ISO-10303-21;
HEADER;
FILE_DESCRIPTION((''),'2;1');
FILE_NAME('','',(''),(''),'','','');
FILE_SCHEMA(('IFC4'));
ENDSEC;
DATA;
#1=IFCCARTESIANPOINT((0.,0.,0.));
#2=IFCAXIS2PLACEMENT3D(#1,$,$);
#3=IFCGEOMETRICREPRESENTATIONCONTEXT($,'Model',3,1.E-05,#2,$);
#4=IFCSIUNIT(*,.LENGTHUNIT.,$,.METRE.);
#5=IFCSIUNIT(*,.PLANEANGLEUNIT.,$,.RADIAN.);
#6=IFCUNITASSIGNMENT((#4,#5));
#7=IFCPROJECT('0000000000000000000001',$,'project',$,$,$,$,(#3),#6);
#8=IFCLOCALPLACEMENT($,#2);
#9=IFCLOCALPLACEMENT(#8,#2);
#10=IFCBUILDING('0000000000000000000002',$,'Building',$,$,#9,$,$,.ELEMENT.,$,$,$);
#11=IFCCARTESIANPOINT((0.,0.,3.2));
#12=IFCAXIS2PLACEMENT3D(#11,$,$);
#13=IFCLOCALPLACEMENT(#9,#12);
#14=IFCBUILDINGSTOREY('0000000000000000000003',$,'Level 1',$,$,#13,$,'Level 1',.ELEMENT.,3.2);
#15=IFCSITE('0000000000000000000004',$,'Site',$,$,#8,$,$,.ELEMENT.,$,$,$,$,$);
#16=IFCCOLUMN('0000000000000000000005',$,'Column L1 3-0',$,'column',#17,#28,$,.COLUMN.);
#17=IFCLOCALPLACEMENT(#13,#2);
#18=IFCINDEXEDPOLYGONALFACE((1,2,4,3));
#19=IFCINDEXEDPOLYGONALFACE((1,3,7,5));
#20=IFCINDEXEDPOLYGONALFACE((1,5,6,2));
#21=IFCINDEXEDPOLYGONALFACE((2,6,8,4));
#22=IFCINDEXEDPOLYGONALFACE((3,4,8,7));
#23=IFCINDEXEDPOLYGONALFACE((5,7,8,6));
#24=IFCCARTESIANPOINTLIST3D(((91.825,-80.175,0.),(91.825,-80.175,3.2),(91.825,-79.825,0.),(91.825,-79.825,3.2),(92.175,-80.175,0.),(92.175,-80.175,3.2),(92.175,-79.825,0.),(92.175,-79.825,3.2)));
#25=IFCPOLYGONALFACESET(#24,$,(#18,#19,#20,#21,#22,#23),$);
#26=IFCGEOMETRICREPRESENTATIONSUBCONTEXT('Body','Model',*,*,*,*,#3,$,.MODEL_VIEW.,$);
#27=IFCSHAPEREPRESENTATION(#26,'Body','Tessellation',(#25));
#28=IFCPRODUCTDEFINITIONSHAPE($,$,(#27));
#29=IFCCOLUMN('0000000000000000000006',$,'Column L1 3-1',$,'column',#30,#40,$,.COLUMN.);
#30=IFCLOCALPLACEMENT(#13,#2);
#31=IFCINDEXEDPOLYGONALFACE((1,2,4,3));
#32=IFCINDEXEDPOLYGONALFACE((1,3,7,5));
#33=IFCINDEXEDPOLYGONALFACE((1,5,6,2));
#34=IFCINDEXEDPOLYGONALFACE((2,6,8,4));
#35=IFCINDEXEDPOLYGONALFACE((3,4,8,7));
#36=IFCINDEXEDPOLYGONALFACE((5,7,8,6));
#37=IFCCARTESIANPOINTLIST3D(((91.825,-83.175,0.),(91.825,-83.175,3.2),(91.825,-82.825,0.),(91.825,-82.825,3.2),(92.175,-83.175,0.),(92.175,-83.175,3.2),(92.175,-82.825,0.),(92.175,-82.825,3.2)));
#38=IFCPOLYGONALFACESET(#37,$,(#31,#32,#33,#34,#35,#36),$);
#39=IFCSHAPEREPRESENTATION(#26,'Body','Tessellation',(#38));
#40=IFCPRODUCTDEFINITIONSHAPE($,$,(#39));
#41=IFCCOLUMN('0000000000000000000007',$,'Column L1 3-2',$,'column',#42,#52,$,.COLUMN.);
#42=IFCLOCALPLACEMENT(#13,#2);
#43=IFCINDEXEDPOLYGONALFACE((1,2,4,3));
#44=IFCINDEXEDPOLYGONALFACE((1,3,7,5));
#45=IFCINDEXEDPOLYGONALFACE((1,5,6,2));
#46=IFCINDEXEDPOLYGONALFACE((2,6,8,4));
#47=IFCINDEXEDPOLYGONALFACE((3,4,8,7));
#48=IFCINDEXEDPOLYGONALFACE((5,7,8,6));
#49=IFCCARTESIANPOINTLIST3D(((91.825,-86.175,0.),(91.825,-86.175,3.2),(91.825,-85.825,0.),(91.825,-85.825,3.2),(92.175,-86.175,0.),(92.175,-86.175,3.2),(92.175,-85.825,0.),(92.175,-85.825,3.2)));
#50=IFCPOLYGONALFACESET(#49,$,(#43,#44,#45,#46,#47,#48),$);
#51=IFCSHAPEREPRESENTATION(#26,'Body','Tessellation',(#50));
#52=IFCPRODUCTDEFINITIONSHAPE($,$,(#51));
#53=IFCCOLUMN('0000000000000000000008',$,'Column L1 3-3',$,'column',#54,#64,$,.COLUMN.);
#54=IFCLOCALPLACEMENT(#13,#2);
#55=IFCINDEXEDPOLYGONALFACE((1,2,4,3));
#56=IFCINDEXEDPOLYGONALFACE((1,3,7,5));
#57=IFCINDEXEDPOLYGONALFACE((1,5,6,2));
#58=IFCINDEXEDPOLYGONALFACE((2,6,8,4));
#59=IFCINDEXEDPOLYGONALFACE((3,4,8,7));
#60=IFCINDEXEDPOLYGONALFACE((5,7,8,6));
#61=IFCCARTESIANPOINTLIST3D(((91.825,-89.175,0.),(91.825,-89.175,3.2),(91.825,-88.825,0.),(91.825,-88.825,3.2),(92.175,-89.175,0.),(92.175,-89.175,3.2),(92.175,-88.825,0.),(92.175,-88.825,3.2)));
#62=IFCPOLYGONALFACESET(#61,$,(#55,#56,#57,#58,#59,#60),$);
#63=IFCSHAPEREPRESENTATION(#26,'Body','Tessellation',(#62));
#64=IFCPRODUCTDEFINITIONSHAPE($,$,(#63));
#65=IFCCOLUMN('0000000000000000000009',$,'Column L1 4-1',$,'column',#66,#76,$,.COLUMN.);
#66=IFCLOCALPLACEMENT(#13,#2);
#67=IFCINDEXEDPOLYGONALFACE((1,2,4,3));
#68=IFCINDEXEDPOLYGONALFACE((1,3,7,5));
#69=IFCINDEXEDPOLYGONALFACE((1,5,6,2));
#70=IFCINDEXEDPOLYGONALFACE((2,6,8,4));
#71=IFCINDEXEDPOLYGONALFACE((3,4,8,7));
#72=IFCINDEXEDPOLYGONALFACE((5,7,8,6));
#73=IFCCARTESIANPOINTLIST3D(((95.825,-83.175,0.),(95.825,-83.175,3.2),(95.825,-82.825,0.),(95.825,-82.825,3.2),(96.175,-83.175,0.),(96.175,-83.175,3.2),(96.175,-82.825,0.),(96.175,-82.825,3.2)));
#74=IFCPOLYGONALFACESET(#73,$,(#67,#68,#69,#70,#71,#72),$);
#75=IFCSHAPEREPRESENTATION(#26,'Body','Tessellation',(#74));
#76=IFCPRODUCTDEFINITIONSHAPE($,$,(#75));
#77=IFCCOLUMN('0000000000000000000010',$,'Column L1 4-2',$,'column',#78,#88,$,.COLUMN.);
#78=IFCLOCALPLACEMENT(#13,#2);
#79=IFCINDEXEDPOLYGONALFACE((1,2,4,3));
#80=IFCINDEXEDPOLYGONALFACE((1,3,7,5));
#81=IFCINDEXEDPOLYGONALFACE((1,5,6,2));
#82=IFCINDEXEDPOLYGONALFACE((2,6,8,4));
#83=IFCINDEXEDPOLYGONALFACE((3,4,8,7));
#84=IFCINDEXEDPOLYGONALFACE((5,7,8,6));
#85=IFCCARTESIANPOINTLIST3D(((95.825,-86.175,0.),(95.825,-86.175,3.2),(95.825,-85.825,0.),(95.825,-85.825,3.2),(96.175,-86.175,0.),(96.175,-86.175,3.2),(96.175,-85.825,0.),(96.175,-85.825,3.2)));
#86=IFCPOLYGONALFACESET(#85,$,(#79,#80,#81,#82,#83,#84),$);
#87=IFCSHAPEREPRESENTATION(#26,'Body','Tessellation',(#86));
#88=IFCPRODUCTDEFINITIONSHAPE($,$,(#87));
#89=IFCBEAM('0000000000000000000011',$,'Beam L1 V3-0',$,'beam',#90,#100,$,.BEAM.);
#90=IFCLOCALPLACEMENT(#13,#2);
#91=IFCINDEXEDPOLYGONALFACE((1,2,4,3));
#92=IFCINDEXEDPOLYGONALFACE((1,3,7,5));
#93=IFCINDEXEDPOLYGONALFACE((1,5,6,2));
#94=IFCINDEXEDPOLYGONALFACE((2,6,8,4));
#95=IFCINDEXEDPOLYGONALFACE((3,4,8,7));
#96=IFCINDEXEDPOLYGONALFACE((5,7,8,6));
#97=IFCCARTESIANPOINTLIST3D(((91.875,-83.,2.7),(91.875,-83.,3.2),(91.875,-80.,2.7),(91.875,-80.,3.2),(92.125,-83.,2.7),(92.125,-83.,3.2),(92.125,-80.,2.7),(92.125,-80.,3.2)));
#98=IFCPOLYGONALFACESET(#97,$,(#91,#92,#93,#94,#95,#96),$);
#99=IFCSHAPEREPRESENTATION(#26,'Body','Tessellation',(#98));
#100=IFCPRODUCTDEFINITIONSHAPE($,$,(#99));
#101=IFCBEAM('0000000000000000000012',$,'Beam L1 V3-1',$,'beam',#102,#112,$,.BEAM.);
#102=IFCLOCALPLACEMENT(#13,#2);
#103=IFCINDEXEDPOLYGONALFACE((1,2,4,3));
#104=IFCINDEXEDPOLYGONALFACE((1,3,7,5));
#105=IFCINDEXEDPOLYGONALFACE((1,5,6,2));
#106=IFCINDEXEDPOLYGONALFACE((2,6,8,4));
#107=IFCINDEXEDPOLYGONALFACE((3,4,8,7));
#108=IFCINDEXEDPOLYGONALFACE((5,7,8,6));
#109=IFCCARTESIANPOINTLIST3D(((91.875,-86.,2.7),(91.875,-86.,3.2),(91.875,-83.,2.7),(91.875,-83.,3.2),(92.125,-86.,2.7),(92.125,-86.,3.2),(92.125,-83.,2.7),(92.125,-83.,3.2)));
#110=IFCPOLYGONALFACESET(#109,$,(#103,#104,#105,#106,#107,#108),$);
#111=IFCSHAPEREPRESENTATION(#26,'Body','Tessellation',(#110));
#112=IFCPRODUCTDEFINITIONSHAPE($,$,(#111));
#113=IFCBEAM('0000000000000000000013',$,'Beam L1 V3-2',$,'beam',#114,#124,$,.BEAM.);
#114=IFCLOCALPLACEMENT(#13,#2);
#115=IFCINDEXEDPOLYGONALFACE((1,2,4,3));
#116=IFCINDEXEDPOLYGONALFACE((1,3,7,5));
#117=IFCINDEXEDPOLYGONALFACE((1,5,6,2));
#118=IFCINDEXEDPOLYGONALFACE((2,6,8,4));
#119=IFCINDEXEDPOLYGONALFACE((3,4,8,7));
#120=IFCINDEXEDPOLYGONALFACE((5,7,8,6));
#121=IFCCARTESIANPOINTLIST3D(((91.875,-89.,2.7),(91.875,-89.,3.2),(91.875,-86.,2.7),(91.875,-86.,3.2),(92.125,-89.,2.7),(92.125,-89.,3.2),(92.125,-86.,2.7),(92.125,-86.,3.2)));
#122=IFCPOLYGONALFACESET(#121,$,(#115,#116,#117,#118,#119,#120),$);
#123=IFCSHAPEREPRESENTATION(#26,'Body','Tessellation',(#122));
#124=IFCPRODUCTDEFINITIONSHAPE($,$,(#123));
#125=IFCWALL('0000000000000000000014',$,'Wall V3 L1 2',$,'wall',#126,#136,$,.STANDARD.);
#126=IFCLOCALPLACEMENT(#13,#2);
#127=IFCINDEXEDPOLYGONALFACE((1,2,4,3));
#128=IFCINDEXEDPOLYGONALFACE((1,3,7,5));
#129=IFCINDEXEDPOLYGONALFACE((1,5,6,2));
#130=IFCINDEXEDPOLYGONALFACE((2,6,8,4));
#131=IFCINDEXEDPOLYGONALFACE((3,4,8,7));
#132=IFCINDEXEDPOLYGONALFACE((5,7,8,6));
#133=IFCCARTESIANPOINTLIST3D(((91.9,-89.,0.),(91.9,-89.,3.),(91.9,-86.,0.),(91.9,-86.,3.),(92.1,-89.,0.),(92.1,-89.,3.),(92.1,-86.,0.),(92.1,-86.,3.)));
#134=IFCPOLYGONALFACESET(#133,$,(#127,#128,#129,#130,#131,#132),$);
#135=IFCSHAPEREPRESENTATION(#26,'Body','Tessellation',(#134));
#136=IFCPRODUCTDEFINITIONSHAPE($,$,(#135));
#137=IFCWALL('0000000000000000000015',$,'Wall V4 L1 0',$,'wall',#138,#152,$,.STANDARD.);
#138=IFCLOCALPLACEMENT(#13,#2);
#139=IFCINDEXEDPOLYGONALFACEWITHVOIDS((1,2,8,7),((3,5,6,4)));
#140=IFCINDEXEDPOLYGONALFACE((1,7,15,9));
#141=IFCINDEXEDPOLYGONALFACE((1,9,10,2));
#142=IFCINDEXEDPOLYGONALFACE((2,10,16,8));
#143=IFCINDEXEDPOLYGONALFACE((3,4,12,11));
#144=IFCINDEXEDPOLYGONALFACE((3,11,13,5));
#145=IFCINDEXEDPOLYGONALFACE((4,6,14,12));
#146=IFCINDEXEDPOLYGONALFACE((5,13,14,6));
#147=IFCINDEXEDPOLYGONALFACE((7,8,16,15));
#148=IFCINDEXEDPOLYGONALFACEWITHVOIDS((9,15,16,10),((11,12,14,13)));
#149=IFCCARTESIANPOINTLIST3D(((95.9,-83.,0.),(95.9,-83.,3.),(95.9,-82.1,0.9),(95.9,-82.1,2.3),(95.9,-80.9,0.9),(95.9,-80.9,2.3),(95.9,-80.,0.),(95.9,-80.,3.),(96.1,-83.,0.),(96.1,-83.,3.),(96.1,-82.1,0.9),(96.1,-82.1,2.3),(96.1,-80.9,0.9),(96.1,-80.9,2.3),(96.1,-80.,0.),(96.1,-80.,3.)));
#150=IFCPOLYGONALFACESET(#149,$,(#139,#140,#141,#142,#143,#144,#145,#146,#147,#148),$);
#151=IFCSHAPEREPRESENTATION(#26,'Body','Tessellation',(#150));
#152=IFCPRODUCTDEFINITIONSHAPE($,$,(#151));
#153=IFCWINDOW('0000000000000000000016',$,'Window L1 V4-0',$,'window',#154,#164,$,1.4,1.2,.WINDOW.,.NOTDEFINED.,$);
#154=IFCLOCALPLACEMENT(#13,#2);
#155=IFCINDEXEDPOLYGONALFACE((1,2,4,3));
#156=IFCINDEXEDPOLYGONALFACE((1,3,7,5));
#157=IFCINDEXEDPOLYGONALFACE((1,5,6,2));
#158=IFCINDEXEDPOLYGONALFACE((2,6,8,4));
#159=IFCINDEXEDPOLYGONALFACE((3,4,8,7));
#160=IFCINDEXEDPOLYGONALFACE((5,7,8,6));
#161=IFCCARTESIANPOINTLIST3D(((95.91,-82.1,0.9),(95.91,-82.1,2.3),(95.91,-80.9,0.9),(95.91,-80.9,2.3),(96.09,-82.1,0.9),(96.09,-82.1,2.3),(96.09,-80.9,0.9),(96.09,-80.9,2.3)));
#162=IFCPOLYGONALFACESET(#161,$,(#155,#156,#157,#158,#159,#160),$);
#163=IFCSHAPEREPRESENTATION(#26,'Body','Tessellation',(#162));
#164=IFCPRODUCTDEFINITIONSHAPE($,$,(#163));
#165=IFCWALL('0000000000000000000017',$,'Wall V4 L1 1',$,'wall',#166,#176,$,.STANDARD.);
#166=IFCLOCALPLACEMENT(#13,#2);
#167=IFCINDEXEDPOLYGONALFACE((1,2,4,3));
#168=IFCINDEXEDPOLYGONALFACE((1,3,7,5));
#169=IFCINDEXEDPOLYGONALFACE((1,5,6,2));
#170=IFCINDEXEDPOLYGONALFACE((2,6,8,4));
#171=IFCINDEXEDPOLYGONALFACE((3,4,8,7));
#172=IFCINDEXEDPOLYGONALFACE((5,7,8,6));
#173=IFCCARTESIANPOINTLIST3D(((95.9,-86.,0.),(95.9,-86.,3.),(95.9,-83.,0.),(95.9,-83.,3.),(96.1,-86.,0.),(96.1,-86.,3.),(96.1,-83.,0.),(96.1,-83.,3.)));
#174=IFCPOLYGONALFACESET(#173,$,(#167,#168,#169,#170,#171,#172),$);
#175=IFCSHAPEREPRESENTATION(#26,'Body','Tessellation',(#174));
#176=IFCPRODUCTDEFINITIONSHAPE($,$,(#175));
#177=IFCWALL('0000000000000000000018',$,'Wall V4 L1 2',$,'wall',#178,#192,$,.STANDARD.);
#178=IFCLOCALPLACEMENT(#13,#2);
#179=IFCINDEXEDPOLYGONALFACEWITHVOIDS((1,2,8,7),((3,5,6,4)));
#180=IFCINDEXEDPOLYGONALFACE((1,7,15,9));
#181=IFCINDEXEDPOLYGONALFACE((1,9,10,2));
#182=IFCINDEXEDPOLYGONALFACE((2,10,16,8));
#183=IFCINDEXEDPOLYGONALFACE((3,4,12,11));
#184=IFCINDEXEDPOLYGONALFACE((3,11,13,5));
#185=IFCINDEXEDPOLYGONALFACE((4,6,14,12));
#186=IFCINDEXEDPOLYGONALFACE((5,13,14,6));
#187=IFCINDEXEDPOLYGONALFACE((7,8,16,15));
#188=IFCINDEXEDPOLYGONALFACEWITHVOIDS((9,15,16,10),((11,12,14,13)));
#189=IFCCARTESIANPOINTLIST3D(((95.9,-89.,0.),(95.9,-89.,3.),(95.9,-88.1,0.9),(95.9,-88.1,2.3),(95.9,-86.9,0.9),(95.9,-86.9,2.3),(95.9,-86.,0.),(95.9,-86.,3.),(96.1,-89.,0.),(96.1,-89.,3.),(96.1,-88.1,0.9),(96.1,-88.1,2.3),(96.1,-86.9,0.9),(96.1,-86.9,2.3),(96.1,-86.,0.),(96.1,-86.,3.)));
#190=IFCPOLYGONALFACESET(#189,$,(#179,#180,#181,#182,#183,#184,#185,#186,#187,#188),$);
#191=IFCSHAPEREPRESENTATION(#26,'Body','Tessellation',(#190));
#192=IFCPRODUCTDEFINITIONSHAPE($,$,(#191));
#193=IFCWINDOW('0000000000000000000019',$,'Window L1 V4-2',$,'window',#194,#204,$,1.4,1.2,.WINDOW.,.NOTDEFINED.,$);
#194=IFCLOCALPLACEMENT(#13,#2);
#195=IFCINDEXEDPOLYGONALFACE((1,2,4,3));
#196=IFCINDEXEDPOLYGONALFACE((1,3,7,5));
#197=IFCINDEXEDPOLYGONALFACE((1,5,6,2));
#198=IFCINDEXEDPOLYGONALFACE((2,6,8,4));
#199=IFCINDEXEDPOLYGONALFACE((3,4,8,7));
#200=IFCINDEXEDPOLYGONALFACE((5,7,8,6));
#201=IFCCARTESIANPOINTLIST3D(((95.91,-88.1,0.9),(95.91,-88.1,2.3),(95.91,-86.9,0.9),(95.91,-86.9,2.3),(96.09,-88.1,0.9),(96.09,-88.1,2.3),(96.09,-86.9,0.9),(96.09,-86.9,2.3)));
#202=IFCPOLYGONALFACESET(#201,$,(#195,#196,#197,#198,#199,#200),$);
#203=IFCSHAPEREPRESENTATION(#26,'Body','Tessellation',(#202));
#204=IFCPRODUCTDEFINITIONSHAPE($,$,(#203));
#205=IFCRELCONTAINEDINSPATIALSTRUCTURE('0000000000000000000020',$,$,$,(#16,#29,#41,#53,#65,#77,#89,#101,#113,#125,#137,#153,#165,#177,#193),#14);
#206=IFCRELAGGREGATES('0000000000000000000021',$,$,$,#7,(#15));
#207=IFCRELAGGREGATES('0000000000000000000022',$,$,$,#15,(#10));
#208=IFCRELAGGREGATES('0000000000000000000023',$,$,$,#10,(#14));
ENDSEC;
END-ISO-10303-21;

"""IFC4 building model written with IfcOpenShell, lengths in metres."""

from ifc_helpers import new_model, si_unit, frame, frame_2d, origin, origin_2d, place, context, subcontext, project, spatial, rectangle, extrude, element, fill, save


model = new_model("IFC4")

# Units and contexts
model_context = context("Model", 3, precision=1e-05, world=origin())
body_context = subcontext(model_context, "Body", "Model", "MODEL_VIEW")
ifc_project = project(units=[si_unit("LENGTHUNIT", "METRE"), si_unit("PLANEANGLEUNIT", "RADIAN")], contexts=[model_context])

# Site, building, storey
site_placement = place(None, origin())
site = spatial("IfcSite", under=ifc_project, at=site_placement, Name="Site", CompositionType="ELEMENT")
building_placement = place(site_placement, origin())
building = spatial("IfcBuilding", under=site, at=building_placement, Name="Building", CompositionType="ELEMENT")
storey_placement = place(building_placement, frame((0.0, 0.0, 3.2)))
storey = spatial("IfcBuildingStorey", under=building, at=storey_placement, Name="Level 1", LongName="Level 1", CompositionType="ELEMENT", Elevation=3.2)

# Columns
for number, where, name in (
    (1, (92.0, -80.0, 0.0), "Column L1 3-0"),
    (2, (92.0, -83.0, 0.0), "Column L1 3-1"),
    (3, (92.0, -86.0, 0.0), "Column L1 3-2"),
    (4, (92.0, -89.0, 0.0), "Column L1 3-3"),
    (5, (96.0, -83.0, 0.0), "Column L1 4-1"),
    (6, (96.0, -86.0, 0.0), "Column L1 4-2"),
):
    element("IfcColumn", number, at=place(storey_placement, frame(where)), inside=storey, Name=name, ObjectType="column", PredefinedType="COLUMN", context=body_context, shape_type="SweptSolid", body=[
        extrude(rectangle(XDim=0.35, YDim=0.35, at=origin_2d()), origin(), (0.0, 0.0, 1.0), 3.2),
    ])

# Beams
for number, where, z_axis, x_axis, name in (
    (7, (92.0, -80.0, 2.95), (0.0, -1.0, 0.0), (0.0, 0.0, 1.0), "Beam L1 V3-0"),
    (8, (92.0, -83.0, 2.95), (0.0, -1.0, 0.0), (0.0, 0.0, 1.0), "Beam L1 V3-1"),
    (9, (92.0, -86.0, 2.95), (0.0, -1.0, 0.0), (0.0, 0.0, 1.0), "Beam L1 V3-2"),
):
    element("IfcBeam", number, at=place(storey_placement, frame(where, z_axis=z_axis, x_axis=x_axis)), inside=storey, Name=name, ObjectType="beam", PredefinedType="BEAM", context=body_context, shape_type="SweptSolid", body=[
        extrude(rectangle(XDim=0.5, YDim=0.25, at=origin_2d()), origin(), (0.0, 0.0, 1.0), 3.0),
    ])

# Wall
wall_1_placement = place(storey_placement, frame((92.0, -86.0, 0.0), z_axis=(0.0, 0.0, 1.0), x_axis=(0.0, -1.0, 0.0)))
element("IfcWall", 10, at=wall_1_placement, inside=storey, Name="Wall V3 L1 2", ObjectType="wall", PredefinedType="STANDARD", context=body_context, shape_type="SweptSolid", body=[
    extrude(rectangle(XDim=3.0, YDim=0.2, at=frame_2d((1.5, 0.0))), origin(), (0.0, 0.0, 1.0), 3.0),
])

# Wall, opening, window
wall_2_placement = place(storey_placement, frame((96.0, -80.0, 0.0), z_axis=(0.0, 0.0, 1.0), x_axis=(0.0, -1.0, 0.0)))
wall_2 = element("IfcWall", 11, at=wall_2_placement, inside=storey, Name="Wall V4 L1 0", ObjectType="wall", PredefinedType="STANDARD", context=body_context, shape_type="SweptSolid", body=[
    extrude(rectangle(XDim=3.0, YDim=0.2, at=frame_2d((1.5, 0.0))), origin(), (0.0, 0.0, 1.0), 3.0),
])
opening_1_placement = place(storey_placement, frame((96.0, -81.5, 0.9), z_axis=(0.0, 0.0, 1.0), x_axis=(0.0, -1.0, 0.0)))
opening_1 = element("IfcOpeningElement", 12, at=opening_1_placement, cuts=wall_2, ObjectType="Opening", PredefinedType="OPENING", context=body_context, shape_type="SweptSolid", body=[
    extrude(rectangle(XDim=1.2, YDim=0.22, at=origin_2d()), origin(), (0.0, 0.0, 1.0), 1.4),
])
window_1_placement = place(storey_placement, frame((96.0, -81.5, 0.9), z_axis=(0.0, 0.0, 1.0), x_axis=(0.0, -1.0, 0.0)))
window_1 = element("IfcWindow", 13, at=window_1_placement, inside=storey, Name="Window L1 V4-0", ObjectType="window", OverallHeight=1.4, OverallWidth=1.2, PartitioningType="NOTDEFINED", PredefinedType="WINDOW", context=body_context, shape_type="SweptSolid", body=[
    extrude(rectangle(XDim=1.2, YDim=0.18, at=origin_2d()), origin(), (0.0, 0.0, 1.0), 1.4),
])
fill(opening_1, window_1)

# Wall
wall_3_placement = place(storey_placement, frame((96.0, -83.0, 0.0), z_axis=(0.0, 0.0, 1.0), x_axis=(0.0, -1.0, 0.0)))
element("IfcWall", 14, at=wall_3_placement, inside=storey, Name="Wall V4 L1 1", ObjectType="wall", PredefinedType="STANDARD", context=body_context, shape_type="SweptSolid", body=[
    extrude(rectangle(XDim=3.0, YDim=0.2, at=frame_2d((1.5, 0.0))), origin(), (0.0, 0.0, 1.0), 3.0),
])

# Wall, opening, window
wall_4_placement = place(storey_placement, frame((96.0, -86.0, 0.0), z_axis=(0.0, 0.0, 1.0), x_axis=(0.0, -1.0, 0.0)))
wall_4 = element("IfcWall", 15, at=wall_4_placement, inside=storey, Name="Wall V4 L1 2", ObjectType="wall", PredefinedType="STANDARD", context=body_context, shape_type="SweptSolid", body=[
    extrude(rectangle(XDim=3.0, YDim=0.2, at=frame_2d((1.5, 0.0))), origin(), (0.0, 0.0, 1.0), 3.0),
])
opening_2_placement = place(storey_placement, frame((96.0, -87.5, 0.9), z_axis=(0.0, 0.0, 1.0), x_axis=(0.0, -1.0, 0.0)))
opening_2 = element("IfcOpeningElement", 16, at=opening_2_placement, cuts=wall_4, ObjectType="Opening", PredefinedType="OPENING", context=body_context, shape_type="SweptSolid", body=[
    extrude(rectangle(XDim=1.2, YDim=0.22, at=origin_2d()), origin(), (0.0, 0.0, 1.0), 1.4),
])
window_2_placement = place(storey_placement, frame((96.0, -87.5, 0.9), z_axis=(0.0, 0.0, 1.0), x_axis=(0.0, -1.0, 0.0)))
window_2 = element("IfcWindow", 17, at=window_2_placement, inside=storey, Name="Window L1 V4-2", ObjectType="window", OverallHeight=1.4, OverallWidth=1.2, PartitioningType="NOTDEFINED", PredefinedType="WINDOW", context=body_context, shape_type="SweptSolid", body=[
    extrude(rectangle(XDim=1.2, YDim=0.18, at=origin_2d()), origin(), (0.0, 0.0, 1.0), 1.4),
])
fill(opening_2, window_2)

save(model, "model.ifc")
